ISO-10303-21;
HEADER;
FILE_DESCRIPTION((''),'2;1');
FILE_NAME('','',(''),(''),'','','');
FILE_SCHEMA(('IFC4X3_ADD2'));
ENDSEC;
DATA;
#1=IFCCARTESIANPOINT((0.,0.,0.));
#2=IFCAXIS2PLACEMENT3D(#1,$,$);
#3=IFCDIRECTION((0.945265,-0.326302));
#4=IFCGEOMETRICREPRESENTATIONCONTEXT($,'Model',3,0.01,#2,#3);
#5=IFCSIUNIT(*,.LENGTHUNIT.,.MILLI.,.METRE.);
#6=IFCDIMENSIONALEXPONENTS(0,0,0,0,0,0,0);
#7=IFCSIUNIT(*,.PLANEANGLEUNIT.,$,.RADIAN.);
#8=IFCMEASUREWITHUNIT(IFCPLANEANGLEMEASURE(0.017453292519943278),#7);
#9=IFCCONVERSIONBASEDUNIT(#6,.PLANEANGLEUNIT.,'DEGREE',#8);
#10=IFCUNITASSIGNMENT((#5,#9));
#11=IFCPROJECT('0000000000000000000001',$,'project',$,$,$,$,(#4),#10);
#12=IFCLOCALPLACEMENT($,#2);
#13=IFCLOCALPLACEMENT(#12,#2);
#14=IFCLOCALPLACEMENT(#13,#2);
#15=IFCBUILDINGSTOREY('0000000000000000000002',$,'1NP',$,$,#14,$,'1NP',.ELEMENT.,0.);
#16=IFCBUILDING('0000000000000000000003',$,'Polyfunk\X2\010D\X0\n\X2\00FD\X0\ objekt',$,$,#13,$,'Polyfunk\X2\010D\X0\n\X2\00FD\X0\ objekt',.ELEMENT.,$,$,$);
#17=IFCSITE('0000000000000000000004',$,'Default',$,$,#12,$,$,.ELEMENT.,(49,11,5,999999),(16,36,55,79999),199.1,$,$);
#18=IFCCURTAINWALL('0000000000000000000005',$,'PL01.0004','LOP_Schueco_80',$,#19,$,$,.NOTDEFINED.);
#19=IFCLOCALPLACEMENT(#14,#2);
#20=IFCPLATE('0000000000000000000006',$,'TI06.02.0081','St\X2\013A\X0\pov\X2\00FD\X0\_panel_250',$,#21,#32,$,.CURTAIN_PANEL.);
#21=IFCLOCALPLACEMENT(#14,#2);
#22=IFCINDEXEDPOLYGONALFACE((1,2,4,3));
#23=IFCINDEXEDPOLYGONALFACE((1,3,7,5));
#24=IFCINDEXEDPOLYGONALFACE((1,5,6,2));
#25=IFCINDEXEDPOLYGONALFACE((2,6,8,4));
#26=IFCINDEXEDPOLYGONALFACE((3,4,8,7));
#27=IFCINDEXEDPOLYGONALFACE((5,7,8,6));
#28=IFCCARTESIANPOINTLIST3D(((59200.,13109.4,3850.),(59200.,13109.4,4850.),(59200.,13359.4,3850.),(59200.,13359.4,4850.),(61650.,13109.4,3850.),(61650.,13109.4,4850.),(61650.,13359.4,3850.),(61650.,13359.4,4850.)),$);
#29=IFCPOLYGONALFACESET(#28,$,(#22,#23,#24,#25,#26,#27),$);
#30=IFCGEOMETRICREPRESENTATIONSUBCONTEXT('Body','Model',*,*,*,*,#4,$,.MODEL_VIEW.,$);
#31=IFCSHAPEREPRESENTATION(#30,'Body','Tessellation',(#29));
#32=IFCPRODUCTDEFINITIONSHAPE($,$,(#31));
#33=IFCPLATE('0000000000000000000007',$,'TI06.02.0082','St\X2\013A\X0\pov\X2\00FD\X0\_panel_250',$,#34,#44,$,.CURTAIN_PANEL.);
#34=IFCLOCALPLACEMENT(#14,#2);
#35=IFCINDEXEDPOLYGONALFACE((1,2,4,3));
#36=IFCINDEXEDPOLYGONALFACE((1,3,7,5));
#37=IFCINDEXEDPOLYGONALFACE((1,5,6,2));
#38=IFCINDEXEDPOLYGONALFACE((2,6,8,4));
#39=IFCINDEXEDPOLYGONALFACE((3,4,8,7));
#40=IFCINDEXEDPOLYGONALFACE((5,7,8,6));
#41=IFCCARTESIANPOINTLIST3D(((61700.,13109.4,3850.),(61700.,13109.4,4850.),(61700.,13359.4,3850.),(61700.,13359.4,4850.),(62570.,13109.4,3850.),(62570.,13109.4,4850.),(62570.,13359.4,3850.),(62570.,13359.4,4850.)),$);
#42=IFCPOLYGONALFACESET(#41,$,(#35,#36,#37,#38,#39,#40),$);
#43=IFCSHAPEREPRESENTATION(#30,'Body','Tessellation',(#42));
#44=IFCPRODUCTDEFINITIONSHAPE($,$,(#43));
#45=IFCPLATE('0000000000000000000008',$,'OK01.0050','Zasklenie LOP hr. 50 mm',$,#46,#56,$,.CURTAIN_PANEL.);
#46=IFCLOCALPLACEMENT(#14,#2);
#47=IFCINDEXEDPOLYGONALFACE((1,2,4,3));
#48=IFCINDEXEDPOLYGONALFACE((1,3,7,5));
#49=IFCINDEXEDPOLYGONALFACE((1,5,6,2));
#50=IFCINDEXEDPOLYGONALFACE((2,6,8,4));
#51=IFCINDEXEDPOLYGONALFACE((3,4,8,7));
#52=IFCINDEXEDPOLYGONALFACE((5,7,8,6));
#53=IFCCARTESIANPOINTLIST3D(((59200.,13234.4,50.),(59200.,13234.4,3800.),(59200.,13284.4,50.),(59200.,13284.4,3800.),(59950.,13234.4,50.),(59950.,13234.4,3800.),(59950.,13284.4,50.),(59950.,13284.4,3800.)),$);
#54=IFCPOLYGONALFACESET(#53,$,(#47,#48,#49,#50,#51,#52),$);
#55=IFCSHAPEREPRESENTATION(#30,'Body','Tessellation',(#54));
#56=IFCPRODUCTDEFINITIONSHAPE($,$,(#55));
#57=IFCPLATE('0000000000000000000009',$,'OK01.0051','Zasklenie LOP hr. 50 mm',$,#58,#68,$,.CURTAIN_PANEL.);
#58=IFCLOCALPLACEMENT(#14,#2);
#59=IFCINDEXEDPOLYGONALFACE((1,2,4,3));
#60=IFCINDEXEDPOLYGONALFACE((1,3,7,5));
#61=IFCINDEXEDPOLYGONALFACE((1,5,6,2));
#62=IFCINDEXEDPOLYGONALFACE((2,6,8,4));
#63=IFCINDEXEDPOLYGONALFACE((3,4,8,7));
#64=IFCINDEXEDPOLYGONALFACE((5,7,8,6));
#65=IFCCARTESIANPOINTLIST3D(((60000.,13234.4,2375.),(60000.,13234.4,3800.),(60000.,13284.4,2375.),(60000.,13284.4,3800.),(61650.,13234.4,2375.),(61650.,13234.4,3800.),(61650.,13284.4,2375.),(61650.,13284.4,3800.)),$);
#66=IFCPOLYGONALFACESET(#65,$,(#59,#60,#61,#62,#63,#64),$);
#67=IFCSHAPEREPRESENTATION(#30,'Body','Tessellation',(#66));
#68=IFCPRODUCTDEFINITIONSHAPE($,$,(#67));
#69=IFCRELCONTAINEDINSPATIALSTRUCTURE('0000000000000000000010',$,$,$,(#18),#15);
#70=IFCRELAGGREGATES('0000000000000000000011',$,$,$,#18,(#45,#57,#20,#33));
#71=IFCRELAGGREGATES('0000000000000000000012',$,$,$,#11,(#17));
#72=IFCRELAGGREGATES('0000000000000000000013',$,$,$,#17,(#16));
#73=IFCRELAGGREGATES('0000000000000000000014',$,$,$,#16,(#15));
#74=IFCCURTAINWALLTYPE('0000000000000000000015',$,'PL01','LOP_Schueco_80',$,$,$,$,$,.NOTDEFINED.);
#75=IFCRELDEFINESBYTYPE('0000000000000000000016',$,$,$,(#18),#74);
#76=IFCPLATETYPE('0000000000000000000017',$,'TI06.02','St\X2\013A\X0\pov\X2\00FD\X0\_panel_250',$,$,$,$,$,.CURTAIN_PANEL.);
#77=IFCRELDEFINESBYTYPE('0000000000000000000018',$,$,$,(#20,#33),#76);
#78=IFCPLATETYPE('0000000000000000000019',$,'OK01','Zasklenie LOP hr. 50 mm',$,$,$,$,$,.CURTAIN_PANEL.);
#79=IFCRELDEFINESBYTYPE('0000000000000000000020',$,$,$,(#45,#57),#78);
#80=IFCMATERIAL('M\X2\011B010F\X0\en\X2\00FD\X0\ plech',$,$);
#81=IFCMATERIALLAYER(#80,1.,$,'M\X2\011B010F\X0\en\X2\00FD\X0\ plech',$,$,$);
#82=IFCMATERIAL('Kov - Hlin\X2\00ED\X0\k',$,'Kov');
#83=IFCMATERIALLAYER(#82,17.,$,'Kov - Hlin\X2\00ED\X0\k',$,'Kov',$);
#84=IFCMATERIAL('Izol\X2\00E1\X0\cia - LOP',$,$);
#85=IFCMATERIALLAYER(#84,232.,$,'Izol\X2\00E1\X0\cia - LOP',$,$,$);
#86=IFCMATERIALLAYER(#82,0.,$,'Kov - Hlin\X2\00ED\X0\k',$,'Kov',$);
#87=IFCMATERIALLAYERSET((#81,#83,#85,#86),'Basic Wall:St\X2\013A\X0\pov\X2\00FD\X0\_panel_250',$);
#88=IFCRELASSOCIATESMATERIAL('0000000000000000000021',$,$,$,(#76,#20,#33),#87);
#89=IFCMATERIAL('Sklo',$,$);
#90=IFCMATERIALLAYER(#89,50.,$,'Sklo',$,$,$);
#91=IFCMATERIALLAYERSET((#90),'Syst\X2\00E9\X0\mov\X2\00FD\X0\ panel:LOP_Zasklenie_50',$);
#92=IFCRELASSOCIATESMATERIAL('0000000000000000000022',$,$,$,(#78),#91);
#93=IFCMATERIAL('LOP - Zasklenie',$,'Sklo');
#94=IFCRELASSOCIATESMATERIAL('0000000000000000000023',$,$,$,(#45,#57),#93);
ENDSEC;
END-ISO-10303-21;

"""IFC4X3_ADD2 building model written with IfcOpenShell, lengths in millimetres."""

from ifc_helpers import new_model, entity, si_unit, converted_unit, direction, frame, frame_2d, origin, origin_2d_with_axis, place, context, subcontext, project, spatial, rectangle, extrude, source, transform, mapped, material, layer, layer_set, layer_usage, type_object, type_shapes, element, aggregate, save


model = new_model("IFC4X3_ADD2")

# Units and contexts
model_context = context("Model", 3, precision=0.01, world=origin(), true_north=direction((0.945265, -0.326302)))
body_context = subcontext(model_context, "Body", "Model", "MODEL_VIEW")
ifc_project = project(units=[si_unit("LENGTHUNIT", "METRE", prefix="MILLI"), converted_unit("PLANEANGLEUNIT", "DEGREE", entity("IfcPlaneAngleMeasure", 0.017453292519943278), si_unit("PLANEANGLEUNIT", "RADIAN"), dimensions=[0, 0, 0, 0, 0, 0, 0])], contexts=[model_context])

# Site, building, storey
site_placement = place(None, origin())
site = spatial("IfcSite", under=ifc_project, at=site_placement, Name="Default", CompositionType="ELEMENT", RefLatitude=(49, 11, 5, 999999), RefLongitude=(16, 36, 55, 79999), RefElevation=199.1)
building_placement = place(site_placement, origin())
building = spatial("IfcBuilding", under=site, at=building_placement, Name="Polyfunkčný objekt", LongName="Polyfunkčný objekt", CompositionType="ELEMENT")
storey_placement = place(building_placement, origin())
storey = spatial("IfcBuildingStorey", under=building, at=storey_placement, Name="1NP", LongName="1NP", CompositionType="ELEMENT", Elevation=0.0)

# Curtain wall, plates
curtain_wall_type = type_object("IfcCurtainWallType", Name="PL01", Description="LOP_Schueco_80", PredefinedType="NOTDEFINED")
curtain_wall_1_placement = place(storey_placement, origin())
curtain_wall_1 = element("IfcCurtainWall", 1, at=curtain_wall_1_placement, inside=storey, type_object=curtain_wall_type, Name="PL01.0004", Description="LOP_Schueco_80", PredefinedType="NOTDEFINED")
ifc_material_1 = material(Name="Měďený plech")
ifc_layer_1 = layer(ifc_material_1, 1.0, Name="Měďený plech")
ifc_material_2 = material(Name="Kov - Hliník", Category="Kov")
ifc_layer_2 = layer(ifc_material_2, 17.0, Name="Kov - Hliník", Category="Kov")
ifc_material_3 = material(Name="Izolácia - LOP")
ifc_layer_3 = layer(ifc_material_3, 232.0, Name="Izolácia - LOP")
ifc_layer_4 = layer(ifc_material_2, 0.0, Name="Kov - Hliník", Category="Kov")
ifc_layer_set_1 = layer_set([ifc_layer_1, ifc_layer_2, ifc_layer_3, ifc_layer_4], Name="Basic Wall:Stĺpový_panel_250")
ifc_layer_usage_1 = layer_usage(ifc_layer_set_1, "AXIS2", "NEGATIVE", 125.0)
plate_type_1 = type_object("IfcPlateType", Name="TI06.02", Description="Stĺpový_panel_250", PredefinedType="CURTAIN_PANEL", material=ifc_layer_set_1)
plate_1_placement = place(storey_placement, frame((59200.0, 13234.4, 3850.0)))
plate_1 = element("IfcPlate", 2, at=plate_1_placement, type_object=plate_type_1, material=ifc_layer_usage_1, Name="TI06.02.0081", Description="Stĺpový_panel_250", PredefinedType="CURTAIN_PANEL", context=body_context, shape_type="SweptSolid", body=[
    extrude(rectangle(XDim=250.0, YDim=2450.0, at=frame_2d((0.0, 0.0), x_axis=(1.0, 0.0))), frame((1225.0, 0.0, 0.0), z_axis=(0.0, 0.0, 1.0), x_axis=(0.0, 1.0, 0.0)), (0.0, 0.0, 1.0), 1000.0),
])
ifc_layer_usage_2 = layer_usage(ifc_layer_set_1, "AXIS2", "NEGATIVE", 125.0)
plate_2_placement = place(storey_placement, frame((61700.0, 13234.4, 3850.0)))
plate_2 = element("IfcPlate", 3, at=plate_2_placement, type_object=plate_type_1, material=ifc_layer_usage_2, Name="TI06.02.0082", Description="Stĺpový_panel_250", PredefinedType="CURTAIN_PANEL", context=body_context, shape_type="SweptSolid", body=[
    extrude(rectangle(XDim=250.0, YDim=870.0, at=frame_2d((0.0, 0.0), x_axis=(1.0, 0.0))), frame((435.0, 0.0, 0.0), z_axis=(0.0, 0.0, 1.0), x_axis=(0.0, 1.0, 0.0)), (0.0, 0.0, 1.0), 1000.0),
])

# Plates
ifc_material_4 = material(Name="LOP - Zasklenie", Category="Sklo")
ifc_material_5 = material(Name="Sklo")
ifc_layer_5 = layer(ifc_material_5, 50.0, Name="Sklo")
ifc_layer_set_2 = layer_set([ifc_layer_5], Name="Systémový panel:LOP_Zasklenie_50")
plate_type_2 = type_object("IfcPlateType", Name="OK01", Description="Zasklenie LOP hr. 50 mm", PredefinedType="CURTAIN_PANEL", material=ifc_layer_set_2)
shared_shape_1 = source(origin(), body_context, "Body", "SweptSolid", [
    extrude(rectangle(XDim=3750.0, YDim=750.0, at=frame_2d((-141.7, 0.0), x_axis=(1.0, 0.0))), frame((0.0, 0.0, 2016.7), z_axis=(0.0, 1.0, 0.0), x_axis=(0.0, 0.0, 1.0)), (0.0, 0.0, 1.0), 50.0),
])
plate_3_placement = place(curtain_wall_1_placement, frame((59575.0, 13234.4, 50.0)))
plate_3 = element("IfcPlate", 4, at=plate_3_placement, type_object=plate_type_2, material=ifc_material_4, Name="OK01.0050", Description="Zasklenie LOP hr. 50 mm", PredefinedType="CURTAIN_PANEL", context=body_context, shape_type="MappedRepresentation", body=[
    mapped(shared_shape_1, transform((0.0, 0.0, 0.0), scale=1.0)),
])
shared_shape_2 = source(origin(), body_context, "Body", "SweptSolid", [
    extrude(rectangle(XDim=50.0, YDim=1650.0, at=origin_2d_with_axis()), frame((0.0, 25.0, 0.0), z_axis=(0.0, 0.0, 1.0), x_axis=(0.0, 1.0, 0.0)), (0.0, 0.0, 1.0), 1425.0),
])
type_shapes(plate_type_2, [shared_shape_1, shared_shape_2])
plate_4_placement = place(curtain_wall_1_placement, frame((60825.0, 13234.4, 2375.0)))
plate_4 = element("IfcPlate", 5, at=plate_4_placement, type_object=plate_type_2, material=ifc_material_4, Name="OK01.0051", Description="Zasklenie LOP hr. 50 mm", PredefinedType="CURTAIN_PANEL", context=body_context, shape_type="MappedRepresentation", body=[
    mapped(shared_shape_2, transform((0.0, 0.0, 0.0), scale=1.0)),
])
aggregate(curtain_wall_1, [plate_3, plate_4, plate_1, plate_2])

save(model, "model.ifc")
